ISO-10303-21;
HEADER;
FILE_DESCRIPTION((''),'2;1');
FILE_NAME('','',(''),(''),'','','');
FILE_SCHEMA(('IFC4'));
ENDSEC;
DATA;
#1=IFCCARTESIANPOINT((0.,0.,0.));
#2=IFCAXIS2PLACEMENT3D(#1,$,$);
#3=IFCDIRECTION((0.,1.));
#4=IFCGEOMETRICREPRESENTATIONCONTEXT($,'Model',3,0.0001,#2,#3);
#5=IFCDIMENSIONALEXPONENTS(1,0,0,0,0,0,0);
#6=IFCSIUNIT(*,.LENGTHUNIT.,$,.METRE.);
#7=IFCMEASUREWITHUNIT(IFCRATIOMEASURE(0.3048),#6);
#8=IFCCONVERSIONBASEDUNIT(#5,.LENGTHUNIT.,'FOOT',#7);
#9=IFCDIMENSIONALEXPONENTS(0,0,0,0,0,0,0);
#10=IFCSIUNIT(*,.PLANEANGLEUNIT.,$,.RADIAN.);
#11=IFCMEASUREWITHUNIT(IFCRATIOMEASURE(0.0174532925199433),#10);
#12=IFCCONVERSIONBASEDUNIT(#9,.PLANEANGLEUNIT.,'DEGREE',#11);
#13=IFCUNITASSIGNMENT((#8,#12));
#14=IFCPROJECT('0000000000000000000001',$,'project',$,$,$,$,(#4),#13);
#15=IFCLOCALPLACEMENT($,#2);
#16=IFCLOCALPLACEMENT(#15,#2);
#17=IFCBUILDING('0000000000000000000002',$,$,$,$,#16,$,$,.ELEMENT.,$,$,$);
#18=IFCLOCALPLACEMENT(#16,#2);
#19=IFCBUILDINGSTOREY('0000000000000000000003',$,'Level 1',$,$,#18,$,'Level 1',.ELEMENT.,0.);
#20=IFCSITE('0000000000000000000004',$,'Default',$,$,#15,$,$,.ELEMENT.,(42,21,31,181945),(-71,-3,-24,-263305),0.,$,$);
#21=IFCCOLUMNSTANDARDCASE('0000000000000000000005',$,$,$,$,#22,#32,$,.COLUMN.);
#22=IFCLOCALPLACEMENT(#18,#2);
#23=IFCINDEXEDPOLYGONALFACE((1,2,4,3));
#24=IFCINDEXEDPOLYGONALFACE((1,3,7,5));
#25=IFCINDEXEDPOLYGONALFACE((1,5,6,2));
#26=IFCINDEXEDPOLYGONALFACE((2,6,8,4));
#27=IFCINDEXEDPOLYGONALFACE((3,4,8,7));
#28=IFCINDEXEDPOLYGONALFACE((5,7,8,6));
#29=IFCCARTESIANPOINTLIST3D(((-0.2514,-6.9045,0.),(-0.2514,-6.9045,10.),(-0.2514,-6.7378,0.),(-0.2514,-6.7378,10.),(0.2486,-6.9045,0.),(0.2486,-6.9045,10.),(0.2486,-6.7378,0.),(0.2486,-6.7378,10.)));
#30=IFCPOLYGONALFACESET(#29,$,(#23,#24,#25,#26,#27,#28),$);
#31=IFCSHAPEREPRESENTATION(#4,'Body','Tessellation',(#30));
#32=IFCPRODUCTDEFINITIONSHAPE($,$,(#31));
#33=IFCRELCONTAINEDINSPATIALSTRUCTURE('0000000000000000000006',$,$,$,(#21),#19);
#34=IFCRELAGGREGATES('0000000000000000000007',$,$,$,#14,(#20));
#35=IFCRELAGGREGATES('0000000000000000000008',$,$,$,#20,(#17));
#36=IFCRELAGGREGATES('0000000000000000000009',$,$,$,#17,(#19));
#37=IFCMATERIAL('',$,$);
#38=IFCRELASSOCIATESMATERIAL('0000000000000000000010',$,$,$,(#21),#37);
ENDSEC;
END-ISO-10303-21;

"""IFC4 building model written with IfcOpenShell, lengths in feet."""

from ifc_helpers import new_model, entity, si_unit, converted_unit, direction, frame, origin, place, context, project, spatial, rectangle, extrude, material, element, save


model = new_model("IFC4")

# Units and contexts
model_context = context("Model", 3, precision=0.0001, world=origin(), true_north=direction((0.0, 1.0)))
ifc_project = project(units=[converted_unit("LENGTHUNIT", "FOOT", entity("IfcRatioMeasure", 0.3048), si_unit("LENGTHUNIT", "METRE"), dimensions=[1, 0, 0, 0, 0, 0, 0]), converted_unit("PLANEANGLEUNIT", "DEGREE", entity("IfcRatioMeasure", 0.0174532925199433), si_unit("PLANEANGLEUNIT", "RADIAN"), dimensions=[0, 0, 0, 0, 0, 0, 0])], contexts=[model_context])

# Site, building, storey
site_placement = place(None, origin())
site = spatial("IfcSite", under=ifc_project, at=site_placement, Name="Default", CompositionType="ELEMENT", RefLatitude=(42, 21, 31, 181945), RefLongitude=(-71, -3, -24, -263305), RefElevation=0.0)
building_placement = place(site_placement, origin())
building = spatial("IfcBuilding", under=site, at=building_placement, CompositionType="ELEMENT")
storey_placement = place(building_placement, origin())
storey = spatial("IfcBuildingStorey", under=building, at=storey_placement, Name="Level 1", LongName="Level 1", CompositionType="ELEMENT", Elevation=0.0)

# Column
ifc_material_1 = material(Name="")
wall_placement = place(storey_placement, frame((-0.0014, -6.9045, 0.0), z_axis=(0.0, 0.0, 1.0), x_axis=(0.0, 1.0, 0.0)))
for number, where, z_axis, x_axis in (
    (1, (0.0833, 0.0, 0.0), (0.0, 0.0, 1.0), (1.0, 0.0, 0.0)),
):
    element("IfcColumnStandardCase", number, at=place(wall_placement, frame(where, z_axis=z_axis, x_axis=x_axis)), inside=storey, material=ifc_material_1, PredefinedType="COLUMN", context=model_context, shape_type="SweptSolid", body=[
        extrude(rectangle(XDim=0.1667, YDim=0.5), origin(), (0.0, 0.0, 1.0), 10.0),
    ])

save(model, "model.ifc")
